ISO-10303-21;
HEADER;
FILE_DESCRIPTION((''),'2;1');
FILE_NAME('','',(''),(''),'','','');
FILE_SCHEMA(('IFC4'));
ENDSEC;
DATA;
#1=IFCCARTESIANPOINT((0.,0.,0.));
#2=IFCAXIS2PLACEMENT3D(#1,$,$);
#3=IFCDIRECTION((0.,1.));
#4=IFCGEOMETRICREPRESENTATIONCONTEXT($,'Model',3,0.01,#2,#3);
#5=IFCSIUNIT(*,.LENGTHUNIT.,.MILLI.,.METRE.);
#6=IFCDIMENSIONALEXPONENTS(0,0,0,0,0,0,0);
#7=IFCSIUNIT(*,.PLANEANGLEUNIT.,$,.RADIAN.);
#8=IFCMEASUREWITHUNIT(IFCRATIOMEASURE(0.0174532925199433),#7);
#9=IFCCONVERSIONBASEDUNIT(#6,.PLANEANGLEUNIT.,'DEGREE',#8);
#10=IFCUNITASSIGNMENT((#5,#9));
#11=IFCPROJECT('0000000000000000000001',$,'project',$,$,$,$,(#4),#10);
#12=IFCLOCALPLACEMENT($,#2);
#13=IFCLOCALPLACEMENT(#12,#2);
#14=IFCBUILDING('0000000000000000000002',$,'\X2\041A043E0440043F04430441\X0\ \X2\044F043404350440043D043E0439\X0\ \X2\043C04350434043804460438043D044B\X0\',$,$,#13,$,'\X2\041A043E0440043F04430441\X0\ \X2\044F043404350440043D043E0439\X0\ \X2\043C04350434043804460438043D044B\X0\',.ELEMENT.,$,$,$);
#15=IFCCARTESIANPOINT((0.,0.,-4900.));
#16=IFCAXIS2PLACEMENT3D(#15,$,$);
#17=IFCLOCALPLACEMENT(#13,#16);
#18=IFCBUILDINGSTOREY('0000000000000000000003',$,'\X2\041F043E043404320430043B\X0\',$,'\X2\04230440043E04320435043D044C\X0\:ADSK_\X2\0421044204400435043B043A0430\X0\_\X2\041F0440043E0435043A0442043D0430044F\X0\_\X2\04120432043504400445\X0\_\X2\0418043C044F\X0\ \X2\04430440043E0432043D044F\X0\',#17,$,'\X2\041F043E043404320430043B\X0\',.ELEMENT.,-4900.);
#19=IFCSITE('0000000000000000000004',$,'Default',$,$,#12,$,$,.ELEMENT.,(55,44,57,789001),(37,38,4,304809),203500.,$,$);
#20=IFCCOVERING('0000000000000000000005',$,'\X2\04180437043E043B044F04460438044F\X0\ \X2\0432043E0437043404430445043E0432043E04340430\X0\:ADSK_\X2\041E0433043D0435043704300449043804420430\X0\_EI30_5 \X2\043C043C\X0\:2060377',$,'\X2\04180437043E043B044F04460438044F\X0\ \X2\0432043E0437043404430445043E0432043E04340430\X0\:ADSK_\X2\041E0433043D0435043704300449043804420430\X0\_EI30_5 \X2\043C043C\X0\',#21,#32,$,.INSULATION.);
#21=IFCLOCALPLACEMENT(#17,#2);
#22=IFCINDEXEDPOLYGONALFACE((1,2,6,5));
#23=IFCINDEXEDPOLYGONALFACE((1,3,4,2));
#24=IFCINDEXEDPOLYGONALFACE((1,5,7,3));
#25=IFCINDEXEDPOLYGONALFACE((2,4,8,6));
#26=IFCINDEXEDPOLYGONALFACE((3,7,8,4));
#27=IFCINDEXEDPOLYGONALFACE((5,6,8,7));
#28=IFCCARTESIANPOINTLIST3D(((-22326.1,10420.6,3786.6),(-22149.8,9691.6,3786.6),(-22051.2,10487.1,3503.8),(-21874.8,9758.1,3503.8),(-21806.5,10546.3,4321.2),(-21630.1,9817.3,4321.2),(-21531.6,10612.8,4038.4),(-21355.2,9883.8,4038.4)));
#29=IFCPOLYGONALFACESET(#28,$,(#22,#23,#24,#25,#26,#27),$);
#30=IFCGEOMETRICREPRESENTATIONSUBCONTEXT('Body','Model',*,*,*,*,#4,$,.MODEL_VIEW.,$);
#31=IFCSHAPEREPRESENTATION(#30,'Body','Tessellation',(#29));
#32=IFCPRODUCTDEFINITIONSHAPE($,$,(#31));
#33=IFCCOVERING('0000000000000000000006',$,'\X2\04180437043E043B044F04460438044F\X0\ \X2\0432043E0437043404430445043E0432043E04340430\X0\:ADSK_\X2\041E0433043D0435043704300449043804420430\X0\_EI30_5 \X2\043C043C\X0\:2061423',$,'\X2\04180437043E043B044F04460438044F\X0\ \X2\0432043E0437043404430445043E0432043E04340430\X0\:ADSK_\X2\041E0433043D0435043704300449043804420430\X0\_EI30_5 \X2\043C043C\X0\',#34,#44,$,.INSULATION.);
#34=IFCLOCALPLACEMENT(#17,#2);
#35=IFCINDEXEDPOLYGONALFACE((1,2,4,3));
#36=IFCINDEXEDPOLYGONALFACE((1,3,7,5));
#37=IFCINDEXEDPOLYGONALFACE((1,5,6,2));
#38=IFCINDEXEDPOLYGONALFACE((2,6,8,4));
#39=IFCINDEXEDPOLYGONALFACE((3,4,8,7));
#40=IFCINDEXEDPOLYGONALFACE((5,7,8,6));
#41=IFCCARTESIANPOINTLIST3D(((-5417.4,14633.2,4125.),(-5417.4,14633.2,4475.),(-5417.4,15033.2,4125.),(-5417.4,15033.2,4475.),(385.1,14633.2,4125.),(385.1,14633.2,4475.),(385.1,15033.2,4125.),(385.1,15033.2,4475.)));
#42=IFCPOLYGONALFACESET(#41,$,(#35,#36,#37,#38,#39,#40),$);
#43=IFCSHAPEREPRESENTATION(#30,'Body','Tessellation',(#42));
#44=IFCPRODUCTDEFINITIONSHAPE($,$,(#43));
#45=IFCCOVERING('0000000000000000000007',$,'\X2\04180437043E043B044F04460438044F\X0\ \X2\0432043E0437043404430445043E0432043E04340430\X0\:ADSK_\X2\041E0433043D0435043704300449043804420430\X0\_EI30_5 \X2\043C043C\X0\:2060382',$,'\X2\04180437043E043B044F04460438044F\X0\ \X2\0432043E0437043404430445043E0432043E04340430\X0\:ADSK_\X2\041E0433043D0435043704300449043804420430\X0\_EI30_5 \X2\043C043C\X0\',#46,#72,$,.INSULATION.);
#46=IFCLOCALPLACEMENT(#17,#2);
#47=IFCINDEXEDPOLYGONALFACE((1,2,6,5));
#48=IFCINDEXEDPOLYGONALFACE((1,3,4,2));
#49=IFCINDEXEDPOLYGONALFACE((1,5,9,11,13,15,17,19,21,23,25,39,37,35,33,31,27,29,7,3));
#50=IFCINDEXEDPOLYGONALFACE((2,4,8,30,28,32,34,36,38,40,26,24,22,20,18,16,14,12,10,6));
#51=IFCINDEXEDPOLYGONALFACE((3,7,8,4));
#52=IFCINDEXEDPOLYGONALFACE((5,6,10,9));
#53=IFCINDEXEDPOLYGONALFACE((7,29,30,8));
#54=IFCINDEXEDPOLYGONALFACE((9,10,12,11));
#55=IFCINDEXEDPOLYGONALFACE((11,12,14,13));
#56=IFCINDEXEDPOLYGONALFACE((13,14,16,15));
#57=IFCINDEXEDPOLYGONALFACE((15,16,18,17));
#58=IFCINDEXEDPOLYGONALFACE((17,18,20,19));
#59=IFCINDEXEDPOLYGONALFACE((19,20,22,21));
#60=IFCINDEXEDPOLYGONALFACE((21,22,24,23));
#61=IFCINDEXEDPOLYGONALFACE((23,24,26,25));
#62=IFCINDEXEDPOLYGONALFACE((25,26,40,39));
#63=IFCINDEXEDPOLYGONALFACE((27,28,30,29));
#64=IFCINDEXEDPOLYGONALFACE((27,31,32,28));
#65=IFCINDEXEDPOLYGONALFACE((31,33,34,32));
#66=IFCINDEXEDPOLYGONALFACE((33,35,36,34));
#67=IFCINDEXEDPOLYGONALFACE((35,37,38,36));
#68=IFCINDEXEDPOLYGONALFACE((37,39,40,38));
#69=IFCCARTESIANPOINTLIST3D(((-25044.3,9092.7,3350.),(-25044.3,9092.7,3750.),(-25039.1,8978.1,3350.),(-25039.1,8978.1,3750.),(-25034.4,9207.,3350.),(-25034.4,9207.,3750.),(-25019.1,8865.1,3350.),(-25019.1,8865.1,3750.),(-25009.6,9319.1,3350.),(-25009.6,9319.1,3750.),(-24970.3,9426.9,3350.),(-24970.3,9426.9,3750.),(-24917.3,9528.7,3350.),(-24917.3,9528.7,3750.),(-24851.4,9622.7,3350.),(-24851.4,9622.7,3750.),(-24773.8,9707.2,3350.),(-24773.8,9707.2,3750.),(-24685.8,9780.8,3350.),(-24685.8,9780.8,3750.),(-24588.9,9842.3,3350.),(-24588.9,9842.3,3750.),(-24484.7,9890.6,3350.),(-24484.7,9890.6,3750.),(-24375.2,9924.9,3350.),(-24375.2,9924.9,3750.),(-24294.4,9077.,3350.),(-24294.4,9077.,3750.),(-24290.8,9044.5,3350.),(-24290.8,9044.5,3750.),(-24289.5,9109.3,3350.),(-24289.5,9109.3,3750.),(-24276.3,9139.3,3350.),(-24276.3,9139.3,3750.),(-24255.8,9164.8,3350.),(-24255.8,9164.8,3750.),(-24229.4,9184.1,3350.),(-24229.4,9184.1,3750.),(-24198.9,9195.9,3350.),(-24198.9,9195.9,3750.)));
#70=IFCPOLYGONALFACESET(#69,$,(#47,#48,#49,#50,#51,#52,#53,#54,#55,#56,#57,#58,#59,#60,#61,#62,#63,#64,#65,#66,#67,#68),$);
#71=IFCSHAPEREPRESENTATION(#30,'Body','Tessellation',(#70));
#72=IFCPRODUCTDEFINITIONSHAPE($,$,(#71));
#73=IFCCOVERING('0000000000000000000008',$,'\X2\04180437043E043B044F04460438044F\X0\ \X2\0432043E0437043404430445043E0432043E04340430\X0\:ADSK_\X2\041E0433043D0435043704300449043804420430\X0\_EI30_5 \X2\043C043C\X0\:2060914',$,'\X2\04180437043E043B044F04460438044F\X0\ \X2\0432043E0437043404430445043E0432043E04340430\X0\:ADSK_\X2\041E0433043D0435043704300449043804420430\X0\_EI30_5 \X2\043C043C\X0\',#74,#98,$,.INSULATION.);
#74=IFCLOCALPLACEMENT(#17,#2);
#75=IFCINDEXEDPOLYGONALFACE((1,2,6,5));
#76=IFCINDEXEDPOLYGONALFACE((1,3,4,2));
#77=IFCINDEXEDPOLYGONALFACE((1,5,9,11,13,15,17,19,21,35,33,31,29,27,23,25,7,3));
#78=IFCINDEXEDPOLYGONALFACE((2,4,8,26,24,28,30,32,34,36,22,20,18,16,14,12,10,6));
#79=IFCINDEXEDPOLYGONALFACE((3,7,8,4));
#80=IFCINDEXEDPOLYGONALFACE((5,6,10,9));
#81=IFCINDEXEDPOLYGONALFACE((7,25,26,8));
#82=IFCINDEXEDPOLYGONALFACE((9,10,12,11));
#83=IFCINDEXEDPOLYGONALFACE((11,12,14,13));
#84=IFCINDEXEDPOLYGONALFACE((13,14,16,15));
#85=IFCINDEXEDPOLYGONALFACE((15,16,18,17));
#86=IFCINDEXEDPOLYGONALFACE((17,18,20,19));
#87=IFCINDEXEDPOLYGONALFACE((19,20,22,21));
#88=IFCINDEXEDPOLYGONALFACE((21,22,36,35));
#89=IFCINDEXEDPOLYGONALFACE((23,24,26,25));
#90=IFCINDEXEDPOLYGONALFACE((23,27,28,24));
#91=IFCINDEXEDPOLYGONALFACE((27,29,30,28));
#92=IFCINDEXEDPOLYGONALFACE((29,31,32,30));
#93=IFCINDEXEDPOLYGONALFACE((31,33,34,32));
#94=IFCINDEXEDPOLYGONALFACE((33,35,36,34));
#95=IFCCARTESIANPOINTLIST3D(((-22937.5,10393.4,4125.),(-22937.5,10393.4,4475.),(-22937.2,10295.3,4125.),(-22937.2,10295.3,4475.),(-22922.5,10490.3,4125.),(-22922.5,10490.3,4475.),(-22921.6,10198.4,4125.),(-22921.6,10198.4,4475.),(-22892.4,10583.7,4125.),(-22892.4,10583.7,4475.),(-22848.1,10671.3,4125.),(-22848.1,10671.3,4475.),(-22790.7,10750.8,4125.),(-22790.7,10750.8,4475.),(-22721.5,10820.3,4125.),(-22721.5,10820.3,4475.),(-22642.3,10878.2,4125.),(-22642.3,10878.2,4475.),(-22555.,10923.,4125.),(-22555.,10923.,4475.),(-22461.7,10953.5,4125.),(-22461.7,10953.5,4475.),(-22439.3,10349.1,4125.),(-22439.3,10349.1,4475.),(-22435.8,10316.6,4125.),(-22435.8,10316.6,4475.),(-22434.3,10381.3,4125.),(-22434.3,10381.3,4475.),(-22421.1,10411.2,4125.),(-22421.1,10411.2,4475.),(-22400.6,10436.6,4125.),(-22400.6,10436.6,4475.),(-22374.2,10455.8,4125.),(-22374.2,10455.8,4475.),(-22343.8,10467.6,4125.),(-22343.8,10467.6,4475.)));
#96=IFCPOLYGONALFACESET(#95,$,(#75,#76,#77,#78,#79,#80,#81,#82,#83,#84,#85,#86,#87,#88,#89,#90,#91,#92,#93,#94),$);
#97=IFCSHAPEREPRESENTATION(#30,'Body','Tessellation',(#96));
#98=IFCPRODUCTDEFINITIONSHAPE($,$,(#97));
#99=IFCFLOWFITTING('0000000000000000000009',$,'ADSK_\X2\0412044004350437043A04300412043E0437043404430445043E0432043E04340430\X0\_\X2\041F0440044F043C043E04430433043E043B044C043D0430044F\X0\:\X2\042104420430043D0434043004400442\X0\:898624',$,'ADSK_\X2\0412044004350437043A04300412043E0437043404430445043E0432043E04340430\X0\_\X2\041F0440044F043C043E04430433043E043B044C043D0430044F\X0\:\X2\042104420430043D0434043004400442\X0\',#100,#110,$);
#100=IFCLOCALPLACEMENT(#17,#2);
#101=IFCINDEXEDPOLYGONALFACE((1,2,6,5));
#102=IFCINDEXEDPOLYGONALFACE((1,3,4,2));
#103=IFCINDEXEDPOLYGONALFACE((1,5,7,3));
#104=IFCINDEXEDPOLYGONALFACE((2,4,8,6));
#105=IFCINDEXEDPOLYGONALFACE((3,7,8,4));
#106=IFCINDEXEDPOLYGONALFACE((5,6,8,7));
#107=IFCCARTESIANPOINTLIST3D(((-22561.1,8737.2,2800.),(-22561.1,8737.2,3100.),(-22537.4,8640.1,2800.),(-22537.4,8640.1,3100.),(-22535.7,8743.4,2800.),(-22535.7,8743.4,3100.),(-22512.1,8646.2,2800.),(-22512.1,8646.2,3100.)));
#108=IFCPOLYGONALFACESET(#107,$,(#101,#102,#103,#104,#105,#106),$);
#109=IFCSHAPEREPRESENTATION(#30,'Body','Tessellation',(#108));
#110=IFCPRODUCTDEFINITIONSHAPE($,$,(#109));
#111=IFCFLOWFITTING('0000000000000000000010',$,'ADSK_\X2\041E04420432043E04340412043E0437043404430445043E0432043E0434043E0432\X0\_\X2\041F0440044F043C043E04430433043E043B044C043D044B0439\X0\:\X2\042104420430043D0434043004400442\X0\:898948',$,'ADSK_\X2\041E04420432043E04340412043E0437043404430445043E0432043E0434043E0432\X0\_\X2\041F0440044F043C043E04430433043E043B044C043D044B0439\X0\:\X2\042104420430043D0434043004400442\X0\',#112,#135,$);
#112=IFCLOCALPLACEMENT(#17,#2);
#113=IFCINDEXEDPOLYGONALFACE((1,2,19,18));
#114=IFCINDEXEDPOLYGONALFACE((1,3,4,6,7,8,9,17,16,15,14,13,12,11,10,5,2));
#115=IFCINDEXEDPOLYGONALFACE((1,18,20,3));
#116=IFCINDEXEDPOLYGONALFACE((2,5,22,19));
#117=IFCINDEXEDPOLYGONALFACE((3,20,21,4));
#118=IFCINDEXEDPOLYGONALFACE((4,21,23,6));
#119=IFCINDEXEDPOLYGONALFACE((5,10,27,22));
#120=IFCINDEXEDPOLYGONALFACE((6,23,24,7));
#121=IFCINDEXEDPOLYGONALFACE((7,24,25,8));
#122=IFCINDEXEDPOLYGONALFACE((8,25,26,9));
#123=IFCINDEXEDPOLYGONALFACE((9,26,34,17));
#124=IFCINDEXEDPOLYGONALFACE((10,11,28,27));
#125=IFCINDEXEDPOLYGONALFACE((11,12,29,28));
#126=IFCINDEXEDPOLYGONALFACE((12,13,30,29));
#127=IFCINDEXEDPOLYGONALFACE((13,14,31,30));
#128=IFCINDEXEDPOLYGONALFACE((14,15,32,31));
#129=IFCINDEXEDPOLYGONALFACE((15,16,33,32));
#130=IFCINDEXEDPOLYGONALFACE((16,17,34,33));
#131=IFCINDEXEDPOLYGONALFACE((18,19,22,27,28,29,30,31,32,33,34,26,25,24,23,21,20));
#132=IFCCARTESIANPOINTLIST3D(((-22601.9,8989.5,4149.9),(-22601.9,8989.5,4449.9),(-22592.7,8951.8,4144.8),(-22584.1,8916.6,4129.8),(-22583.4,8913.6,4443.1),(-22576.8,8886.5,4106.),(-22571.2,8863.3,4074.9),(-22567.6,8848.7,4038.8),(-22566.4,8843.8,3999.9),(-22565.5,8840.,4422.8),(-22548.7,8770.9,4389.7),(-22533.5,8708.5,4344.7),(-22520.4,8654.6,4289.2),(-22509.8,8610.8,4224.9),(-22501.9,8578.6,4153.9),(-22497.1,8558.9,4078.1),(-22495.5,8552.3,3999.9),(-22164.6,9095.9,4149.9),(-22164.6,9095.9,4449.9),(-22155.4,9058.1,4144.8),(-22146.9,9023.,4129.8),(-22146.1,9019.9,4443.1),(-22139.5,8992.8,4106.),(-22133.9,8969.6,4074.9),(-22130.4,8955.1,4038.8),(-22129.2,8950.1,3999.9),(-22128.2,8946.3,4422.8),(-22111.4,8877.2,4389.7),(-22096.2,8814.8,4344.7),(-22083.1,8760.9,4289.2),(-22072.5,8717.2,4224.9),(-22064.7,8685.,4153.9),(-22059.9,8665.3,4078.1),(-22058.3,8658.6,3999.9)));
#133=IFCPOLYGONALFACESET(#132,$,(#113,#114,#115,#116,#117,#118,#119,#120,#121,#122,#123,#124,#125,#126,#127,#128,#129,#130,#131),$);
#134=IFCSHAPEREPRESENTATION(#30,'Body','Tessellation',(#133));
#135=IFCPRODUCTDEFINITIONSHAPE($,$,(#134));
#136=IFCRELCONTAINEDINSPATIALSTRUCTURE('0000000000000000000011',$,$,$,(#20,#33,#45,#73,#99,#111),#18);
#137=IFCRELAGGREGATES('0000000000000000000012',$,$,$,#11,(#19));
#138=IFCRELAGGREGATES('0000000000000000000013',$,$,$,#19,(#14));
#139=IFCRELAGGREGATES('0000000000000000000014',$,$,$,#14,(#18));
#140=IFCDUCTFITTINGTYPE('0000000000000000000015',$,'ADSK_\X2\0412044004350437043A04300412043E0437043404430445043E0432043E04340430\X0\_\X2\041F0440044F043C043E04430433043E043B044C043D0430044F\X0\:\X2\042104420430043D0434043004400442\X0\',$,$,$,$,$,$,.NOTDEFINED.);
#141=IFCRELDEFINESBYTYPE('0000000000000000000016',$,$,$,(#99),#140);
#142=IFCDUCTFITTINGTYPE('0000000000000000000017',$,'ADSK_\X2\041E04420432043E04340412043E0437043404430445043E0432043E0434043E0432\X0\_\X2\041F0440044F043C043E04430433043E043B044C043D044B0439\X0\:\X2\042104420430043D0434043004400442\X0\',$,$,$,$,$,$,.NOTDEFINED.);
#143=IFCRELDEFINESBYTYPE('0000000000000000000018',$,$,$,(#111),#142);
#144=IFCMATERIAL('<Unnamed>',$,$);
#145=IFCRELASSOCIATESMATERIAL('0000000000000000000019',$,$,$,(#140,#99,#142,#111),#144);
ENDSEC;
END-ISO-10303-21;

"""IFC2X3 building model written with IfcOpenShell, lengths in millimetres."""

from ifc_helpers import new_model, entity, si_unit, converted_unit, direction, frame, frame_2d, origin, origin_2d_with_axis, place, context, subcontext, project, spatial, polyline, circle_curve, parameter, trimmed, segment, composite_curve, rectangle, outline, extrude, source, transform, mapped, material, type_object, type_shapes, element, save


model = new_model("IFC2X3")

# Units and contexts
model_context = context("Model", 3, precision=0.01, world=origin(), true_north=direction((0.0, 1.0)))
body_context = subcontext(model_context, "Body", "Model", "MODEL_VIEW")
ifc_project = project(units=[si_unit("LENGTHUNIT", "METRE", prefix="MILLI"), converted_unit("PLANEANGLEUNIT", "DEGREE", entity("IfcRatioMeasure", 0.0174532925199433), si_unit("PLANEANGLEUNIT", "RADIAN"), dimensions=[0, 0, 0, 0, 0, 0, 0])], contexts=[model_context])

# Site, building, storey
site_placement = place(None, origin())
site = spatial("IfcSite", under=ifc_project, at=site_placement, Name="Default", CompositionType="ELEMENT", RefLatitude=(55, 44, 57, 789001), RefLongitude=(37, 38, 4, 304809), RefElevation=203500.0)
building_placement = place(site_placement, origin())
building = spatial("IfcBuilding", under=site, at=building_placement, Name="Корпус ядерной медицины", LongName="Корпус ядерной медицины", CompositionType="ELEMENT")
storey_placement = place(building_placement, frame((0.0, 0.0, -4900.0)))
storey = spatial("IfcBuildingStorey", under=building, at=storey_placement, Name="Подвал", ObjectType="Уровень:ADSK_Стрелка_Проектная_Вверх_Имя уровня", LongName="Подвал", CompositionType="ELEMENT", Elevation=-4900.0)

# Coverings
covering_1_placement = place(storey_placement, frame((-22326.1, 9691.6, 3503.8)))
element("IfcCovering", 1, at=covering_1_placement, inside=storey, Name="Изоляция воздуховода:ADSK_Огнезащита_EI30_5 мм:2060377", ObjectType="Изоляция воздуховода:ADSK_Огнезащита_EI30_5 мм", PredefinedType="INSULATION", context=body_context, shape_type="SweptSolid", body=[
    extrude(rectangle(XDim=400.0, YDim=750.0, at=frame_2d((0.0, 0.0), x_axis=(0.0, 1.0))), frame((225.6, 397.7, 141.4), z_axis=(0.687282, 0.166262, 0.707107), x_axis=(0.23513, -0.971964, 0.0)), (0.0, 0.0, 1.0), 756.1),
])
covering_2_placement = place(storey_placement, frame((-5417.4, 14633.2, 4125.0)))
element("IfcCovering", 2, at=covering_2_placement, inside=storey, Name="Изоляция воздуховода:ADSK_Огнезащита_EI30_5 мм:2061423", ObjectType="Изоляция воздуховода:ADSK_Огнезащита_EI30_5 мм", PredefinedType="INSULATION", context=body_context, shape_type="SweptSolid", body=[
    extrude(rectangle(XDim=5802.5, YDim=400.0, at=origin_2d_with_axis()), frame((2901.2, 200.0, 0.0), z_axis=(0.0, 0.0, 1.0), x_axis=(-1.0, 0.0, 0.0)), (0.0, 0.0, 1.0), 350.0),
])
covering_3_placement = place(storey_placement, frame((-25045.9, 8863.5, 3350.0)))
element("IfcCovering", 3, at=covering_3_placement, inside=storey, Name="Изоляция воздуховода:ADSK_Огнезащита_EI30_5 мм:2060382", ObjectType="Изоляция воздуховода:ADSK_Огнезащита_EI30_5 мм", PredefinedType="INSULATION", context=body_context, shape_type="SweptSolid", body=[
    extrude(outline(composite_curve([segment(polyline([(-249.5, 125.0), (-252.6, -625.0)]), True, "CONTINUOUS"), segment(trimmed(circle_curve(frame_2d((-248.9, 250.0), x_axis=(1.0, 0.0)), 875.0), [parameter(269.757898)], [parameter(0.0)], True, "PARAMETER"), True, "CONTINUOUS"), segment(polyline([(626.1, 250.0), (-123.9, 250.0)]), True, "CONTINUOUS"), segment(trimmed(circle_curve(frame_2d((-248.9, 250.0), x_axis=(1.0, 0.0)), 125.0), [parameter(269.757898)], [parameter(360.0)], True, "PARAMETER"), False, "CONTINUOUS")], self_intersect=False)), frame((575.0, 394.1, 0.0), z_axis=(0.0, 0.0, -1.0), x_axis=(-0.23513, 0.971964, 0.0)), (0.0, 0.0, -1.0), 400.0),
])
covering_4_placement = place(storey_placement, frame((-22940.2, 10196.9, 4125.0)))
element("IfcCovering", 4, at=covering_4_placement, inside=storey, Name="Изоляция воздуховода:ADSK_Огнезащита_EI30_5 мм:2060914", ObjectType="Изоляция воздуховода:ADSK_Огнезащита_EI30_5 мм", PredefinedType="INSULATION", context=body_context, shape_type="SweptSolid", body=[
    extrude(outline(composite_curve([segment(polyline([(-187.5, 62.5), (-187.7, -437.5)]), True, "CONTINUOUS"), segment(trimmed(circle_curve(frame_2d((-187.4, 187.5), x_axis=(1.0, 0.0)), 625.0), [parameter(269.972842)], [parameter(0.0)], True, "PARAMETER"), True, "CONTINUOUS"), segment(polyline([(437.6, 187.5), (-62.4, 187.5)]), True, "CONTINUOUS"), segment(trimmed(circle_curve(frame_2d((-187.4, 187.5), x_axis=(1.0, 0.0)), 125.0), [parameter(269.972842)], [parameter(360.0)], True, "PARAMETER"), False, "CONTINUOUS")], self_intersect=False)), frame((399.5, 287.2, 0.0), z_axis=(-0.000003, 0.000014, -1.0), x_axis=(-0.235858, 0.971788, 0.000014)), (0.0, 0.0, -1.0), 350.0),
])

# Flow fittings
ifc_material = material(Name="<Unnamed>")
duct_fitting_type_1 = type_object("IfcDuctFittingType", Name="ADSK_ВрезкаВоздуховода_Прямоугольная:Стандарт", PredefinedType="NOTDEFINED", material=ifc_material)
shared_shape_1 = source(origin(), body_context, "Body", "SweptSolid", [
    extrude(rectangle(XDim=26.1, YDim=300.0, at=origin_2d_with_axis()), frame((7.0, 0.0, -50.0)), (0.0, 0.0, 1.0), 100.0),
])
type_shapes(duct_fitting_type_1, [shared_shape_1])
flow_fitting_1_placement = place(storey_placement, frame((-22529.8, 8693.4, 2950.0), z_axis=(-0.236338, 0.971671, 0.0), x_axis=(-0.971671, -0.236338, 0.0)))
element("IfcFlowFitting", 5, at=flow_fitting_1_placement, inside=storey, type_object=duct_fitting_type_1, material=ifc_material, Name="ADSK_ВрезкаВоздуховода_Прямоугольная:Стандарт:898624", ObjectType="ADSK_ВрезкаВоздуховода_Прямоугольная:Стандарт", context=body_context, shape_type="MappedRepresentation", body=[
    mapped(shared_shape_1, transform((0.0, 0.0, 0.0), scale=1.0)),
])
duct_fitting_type_2 = type_object("IfcDuctFittingType", Name="ADSK_ОтводВоздуховодов_Прямоугольный:Стандарт", PredefinedType="NOTDEFINED", material=ifc_material)
shared_shape_2 = source(origin(), body_context, "Body", "SweptSolid", [
    extrude(outline(composite_curve([segment(polyline([(-300.0, -150.0), (0.0, -150.0)]), True, "CONTINUOUS"), segment(trimmed(circle_curve(frame_2d((150.0, -150.0), x_axis=(-0.000039, 1.0)), 150.0), [parameter(0.0)], [parameter(89.99777)], True, "PARAMETER"), False, "CONTINUOUS"), segment(polyline([(150.0, 0.0), (150.0, 300.0)]), True, "CONTINUOUS"), segment(trimmed(circle_curve(frame_2d((150.0, -150.0), x_axis=(-0.000039, 1.0)), 450.0), [parameter(0.0)], [parameter(89.99777)], True, "PARAMETER"), True, "CONTINUOUS")], self_intersect=False)), frame((-150.0, 150.0, -225.0), z_axis=(0.0, 0.0, 1.0), x_axis=(-1.0, 0.000039, 0.0)), (0.0, 0.0, 1.0), 450.0),
])
type_shapes(duct_fitting_type_2, [shared_shape_2])
flow_fitting_2_placement = place(storey_placement, frame((-22312.3, 8751.2, 4299.9), z_axis=(-0.971671, -0.236338, 0.0), x_axis=(0.0, 0.0, 1.0)))
element("IfcFlowFitting", 6, at=flow_fitting_2_placement, inside=storey, type_object=duct_fitting_type_2, material=ifc_material, Name="ADSK_ОтводВоздуховодов_Прямоугольный:Стандарт:898948", ObjectType="ADSK_ОтводВоздуховодов_Прямоугольный:Стандарт", context=body_context, shape_type="MappedRepresentation", body=[
    mapped(shared_shape_2, transform((0.0, 0.0, 0.0), scale=1.0)),
])

save(model, "model.ifc")
